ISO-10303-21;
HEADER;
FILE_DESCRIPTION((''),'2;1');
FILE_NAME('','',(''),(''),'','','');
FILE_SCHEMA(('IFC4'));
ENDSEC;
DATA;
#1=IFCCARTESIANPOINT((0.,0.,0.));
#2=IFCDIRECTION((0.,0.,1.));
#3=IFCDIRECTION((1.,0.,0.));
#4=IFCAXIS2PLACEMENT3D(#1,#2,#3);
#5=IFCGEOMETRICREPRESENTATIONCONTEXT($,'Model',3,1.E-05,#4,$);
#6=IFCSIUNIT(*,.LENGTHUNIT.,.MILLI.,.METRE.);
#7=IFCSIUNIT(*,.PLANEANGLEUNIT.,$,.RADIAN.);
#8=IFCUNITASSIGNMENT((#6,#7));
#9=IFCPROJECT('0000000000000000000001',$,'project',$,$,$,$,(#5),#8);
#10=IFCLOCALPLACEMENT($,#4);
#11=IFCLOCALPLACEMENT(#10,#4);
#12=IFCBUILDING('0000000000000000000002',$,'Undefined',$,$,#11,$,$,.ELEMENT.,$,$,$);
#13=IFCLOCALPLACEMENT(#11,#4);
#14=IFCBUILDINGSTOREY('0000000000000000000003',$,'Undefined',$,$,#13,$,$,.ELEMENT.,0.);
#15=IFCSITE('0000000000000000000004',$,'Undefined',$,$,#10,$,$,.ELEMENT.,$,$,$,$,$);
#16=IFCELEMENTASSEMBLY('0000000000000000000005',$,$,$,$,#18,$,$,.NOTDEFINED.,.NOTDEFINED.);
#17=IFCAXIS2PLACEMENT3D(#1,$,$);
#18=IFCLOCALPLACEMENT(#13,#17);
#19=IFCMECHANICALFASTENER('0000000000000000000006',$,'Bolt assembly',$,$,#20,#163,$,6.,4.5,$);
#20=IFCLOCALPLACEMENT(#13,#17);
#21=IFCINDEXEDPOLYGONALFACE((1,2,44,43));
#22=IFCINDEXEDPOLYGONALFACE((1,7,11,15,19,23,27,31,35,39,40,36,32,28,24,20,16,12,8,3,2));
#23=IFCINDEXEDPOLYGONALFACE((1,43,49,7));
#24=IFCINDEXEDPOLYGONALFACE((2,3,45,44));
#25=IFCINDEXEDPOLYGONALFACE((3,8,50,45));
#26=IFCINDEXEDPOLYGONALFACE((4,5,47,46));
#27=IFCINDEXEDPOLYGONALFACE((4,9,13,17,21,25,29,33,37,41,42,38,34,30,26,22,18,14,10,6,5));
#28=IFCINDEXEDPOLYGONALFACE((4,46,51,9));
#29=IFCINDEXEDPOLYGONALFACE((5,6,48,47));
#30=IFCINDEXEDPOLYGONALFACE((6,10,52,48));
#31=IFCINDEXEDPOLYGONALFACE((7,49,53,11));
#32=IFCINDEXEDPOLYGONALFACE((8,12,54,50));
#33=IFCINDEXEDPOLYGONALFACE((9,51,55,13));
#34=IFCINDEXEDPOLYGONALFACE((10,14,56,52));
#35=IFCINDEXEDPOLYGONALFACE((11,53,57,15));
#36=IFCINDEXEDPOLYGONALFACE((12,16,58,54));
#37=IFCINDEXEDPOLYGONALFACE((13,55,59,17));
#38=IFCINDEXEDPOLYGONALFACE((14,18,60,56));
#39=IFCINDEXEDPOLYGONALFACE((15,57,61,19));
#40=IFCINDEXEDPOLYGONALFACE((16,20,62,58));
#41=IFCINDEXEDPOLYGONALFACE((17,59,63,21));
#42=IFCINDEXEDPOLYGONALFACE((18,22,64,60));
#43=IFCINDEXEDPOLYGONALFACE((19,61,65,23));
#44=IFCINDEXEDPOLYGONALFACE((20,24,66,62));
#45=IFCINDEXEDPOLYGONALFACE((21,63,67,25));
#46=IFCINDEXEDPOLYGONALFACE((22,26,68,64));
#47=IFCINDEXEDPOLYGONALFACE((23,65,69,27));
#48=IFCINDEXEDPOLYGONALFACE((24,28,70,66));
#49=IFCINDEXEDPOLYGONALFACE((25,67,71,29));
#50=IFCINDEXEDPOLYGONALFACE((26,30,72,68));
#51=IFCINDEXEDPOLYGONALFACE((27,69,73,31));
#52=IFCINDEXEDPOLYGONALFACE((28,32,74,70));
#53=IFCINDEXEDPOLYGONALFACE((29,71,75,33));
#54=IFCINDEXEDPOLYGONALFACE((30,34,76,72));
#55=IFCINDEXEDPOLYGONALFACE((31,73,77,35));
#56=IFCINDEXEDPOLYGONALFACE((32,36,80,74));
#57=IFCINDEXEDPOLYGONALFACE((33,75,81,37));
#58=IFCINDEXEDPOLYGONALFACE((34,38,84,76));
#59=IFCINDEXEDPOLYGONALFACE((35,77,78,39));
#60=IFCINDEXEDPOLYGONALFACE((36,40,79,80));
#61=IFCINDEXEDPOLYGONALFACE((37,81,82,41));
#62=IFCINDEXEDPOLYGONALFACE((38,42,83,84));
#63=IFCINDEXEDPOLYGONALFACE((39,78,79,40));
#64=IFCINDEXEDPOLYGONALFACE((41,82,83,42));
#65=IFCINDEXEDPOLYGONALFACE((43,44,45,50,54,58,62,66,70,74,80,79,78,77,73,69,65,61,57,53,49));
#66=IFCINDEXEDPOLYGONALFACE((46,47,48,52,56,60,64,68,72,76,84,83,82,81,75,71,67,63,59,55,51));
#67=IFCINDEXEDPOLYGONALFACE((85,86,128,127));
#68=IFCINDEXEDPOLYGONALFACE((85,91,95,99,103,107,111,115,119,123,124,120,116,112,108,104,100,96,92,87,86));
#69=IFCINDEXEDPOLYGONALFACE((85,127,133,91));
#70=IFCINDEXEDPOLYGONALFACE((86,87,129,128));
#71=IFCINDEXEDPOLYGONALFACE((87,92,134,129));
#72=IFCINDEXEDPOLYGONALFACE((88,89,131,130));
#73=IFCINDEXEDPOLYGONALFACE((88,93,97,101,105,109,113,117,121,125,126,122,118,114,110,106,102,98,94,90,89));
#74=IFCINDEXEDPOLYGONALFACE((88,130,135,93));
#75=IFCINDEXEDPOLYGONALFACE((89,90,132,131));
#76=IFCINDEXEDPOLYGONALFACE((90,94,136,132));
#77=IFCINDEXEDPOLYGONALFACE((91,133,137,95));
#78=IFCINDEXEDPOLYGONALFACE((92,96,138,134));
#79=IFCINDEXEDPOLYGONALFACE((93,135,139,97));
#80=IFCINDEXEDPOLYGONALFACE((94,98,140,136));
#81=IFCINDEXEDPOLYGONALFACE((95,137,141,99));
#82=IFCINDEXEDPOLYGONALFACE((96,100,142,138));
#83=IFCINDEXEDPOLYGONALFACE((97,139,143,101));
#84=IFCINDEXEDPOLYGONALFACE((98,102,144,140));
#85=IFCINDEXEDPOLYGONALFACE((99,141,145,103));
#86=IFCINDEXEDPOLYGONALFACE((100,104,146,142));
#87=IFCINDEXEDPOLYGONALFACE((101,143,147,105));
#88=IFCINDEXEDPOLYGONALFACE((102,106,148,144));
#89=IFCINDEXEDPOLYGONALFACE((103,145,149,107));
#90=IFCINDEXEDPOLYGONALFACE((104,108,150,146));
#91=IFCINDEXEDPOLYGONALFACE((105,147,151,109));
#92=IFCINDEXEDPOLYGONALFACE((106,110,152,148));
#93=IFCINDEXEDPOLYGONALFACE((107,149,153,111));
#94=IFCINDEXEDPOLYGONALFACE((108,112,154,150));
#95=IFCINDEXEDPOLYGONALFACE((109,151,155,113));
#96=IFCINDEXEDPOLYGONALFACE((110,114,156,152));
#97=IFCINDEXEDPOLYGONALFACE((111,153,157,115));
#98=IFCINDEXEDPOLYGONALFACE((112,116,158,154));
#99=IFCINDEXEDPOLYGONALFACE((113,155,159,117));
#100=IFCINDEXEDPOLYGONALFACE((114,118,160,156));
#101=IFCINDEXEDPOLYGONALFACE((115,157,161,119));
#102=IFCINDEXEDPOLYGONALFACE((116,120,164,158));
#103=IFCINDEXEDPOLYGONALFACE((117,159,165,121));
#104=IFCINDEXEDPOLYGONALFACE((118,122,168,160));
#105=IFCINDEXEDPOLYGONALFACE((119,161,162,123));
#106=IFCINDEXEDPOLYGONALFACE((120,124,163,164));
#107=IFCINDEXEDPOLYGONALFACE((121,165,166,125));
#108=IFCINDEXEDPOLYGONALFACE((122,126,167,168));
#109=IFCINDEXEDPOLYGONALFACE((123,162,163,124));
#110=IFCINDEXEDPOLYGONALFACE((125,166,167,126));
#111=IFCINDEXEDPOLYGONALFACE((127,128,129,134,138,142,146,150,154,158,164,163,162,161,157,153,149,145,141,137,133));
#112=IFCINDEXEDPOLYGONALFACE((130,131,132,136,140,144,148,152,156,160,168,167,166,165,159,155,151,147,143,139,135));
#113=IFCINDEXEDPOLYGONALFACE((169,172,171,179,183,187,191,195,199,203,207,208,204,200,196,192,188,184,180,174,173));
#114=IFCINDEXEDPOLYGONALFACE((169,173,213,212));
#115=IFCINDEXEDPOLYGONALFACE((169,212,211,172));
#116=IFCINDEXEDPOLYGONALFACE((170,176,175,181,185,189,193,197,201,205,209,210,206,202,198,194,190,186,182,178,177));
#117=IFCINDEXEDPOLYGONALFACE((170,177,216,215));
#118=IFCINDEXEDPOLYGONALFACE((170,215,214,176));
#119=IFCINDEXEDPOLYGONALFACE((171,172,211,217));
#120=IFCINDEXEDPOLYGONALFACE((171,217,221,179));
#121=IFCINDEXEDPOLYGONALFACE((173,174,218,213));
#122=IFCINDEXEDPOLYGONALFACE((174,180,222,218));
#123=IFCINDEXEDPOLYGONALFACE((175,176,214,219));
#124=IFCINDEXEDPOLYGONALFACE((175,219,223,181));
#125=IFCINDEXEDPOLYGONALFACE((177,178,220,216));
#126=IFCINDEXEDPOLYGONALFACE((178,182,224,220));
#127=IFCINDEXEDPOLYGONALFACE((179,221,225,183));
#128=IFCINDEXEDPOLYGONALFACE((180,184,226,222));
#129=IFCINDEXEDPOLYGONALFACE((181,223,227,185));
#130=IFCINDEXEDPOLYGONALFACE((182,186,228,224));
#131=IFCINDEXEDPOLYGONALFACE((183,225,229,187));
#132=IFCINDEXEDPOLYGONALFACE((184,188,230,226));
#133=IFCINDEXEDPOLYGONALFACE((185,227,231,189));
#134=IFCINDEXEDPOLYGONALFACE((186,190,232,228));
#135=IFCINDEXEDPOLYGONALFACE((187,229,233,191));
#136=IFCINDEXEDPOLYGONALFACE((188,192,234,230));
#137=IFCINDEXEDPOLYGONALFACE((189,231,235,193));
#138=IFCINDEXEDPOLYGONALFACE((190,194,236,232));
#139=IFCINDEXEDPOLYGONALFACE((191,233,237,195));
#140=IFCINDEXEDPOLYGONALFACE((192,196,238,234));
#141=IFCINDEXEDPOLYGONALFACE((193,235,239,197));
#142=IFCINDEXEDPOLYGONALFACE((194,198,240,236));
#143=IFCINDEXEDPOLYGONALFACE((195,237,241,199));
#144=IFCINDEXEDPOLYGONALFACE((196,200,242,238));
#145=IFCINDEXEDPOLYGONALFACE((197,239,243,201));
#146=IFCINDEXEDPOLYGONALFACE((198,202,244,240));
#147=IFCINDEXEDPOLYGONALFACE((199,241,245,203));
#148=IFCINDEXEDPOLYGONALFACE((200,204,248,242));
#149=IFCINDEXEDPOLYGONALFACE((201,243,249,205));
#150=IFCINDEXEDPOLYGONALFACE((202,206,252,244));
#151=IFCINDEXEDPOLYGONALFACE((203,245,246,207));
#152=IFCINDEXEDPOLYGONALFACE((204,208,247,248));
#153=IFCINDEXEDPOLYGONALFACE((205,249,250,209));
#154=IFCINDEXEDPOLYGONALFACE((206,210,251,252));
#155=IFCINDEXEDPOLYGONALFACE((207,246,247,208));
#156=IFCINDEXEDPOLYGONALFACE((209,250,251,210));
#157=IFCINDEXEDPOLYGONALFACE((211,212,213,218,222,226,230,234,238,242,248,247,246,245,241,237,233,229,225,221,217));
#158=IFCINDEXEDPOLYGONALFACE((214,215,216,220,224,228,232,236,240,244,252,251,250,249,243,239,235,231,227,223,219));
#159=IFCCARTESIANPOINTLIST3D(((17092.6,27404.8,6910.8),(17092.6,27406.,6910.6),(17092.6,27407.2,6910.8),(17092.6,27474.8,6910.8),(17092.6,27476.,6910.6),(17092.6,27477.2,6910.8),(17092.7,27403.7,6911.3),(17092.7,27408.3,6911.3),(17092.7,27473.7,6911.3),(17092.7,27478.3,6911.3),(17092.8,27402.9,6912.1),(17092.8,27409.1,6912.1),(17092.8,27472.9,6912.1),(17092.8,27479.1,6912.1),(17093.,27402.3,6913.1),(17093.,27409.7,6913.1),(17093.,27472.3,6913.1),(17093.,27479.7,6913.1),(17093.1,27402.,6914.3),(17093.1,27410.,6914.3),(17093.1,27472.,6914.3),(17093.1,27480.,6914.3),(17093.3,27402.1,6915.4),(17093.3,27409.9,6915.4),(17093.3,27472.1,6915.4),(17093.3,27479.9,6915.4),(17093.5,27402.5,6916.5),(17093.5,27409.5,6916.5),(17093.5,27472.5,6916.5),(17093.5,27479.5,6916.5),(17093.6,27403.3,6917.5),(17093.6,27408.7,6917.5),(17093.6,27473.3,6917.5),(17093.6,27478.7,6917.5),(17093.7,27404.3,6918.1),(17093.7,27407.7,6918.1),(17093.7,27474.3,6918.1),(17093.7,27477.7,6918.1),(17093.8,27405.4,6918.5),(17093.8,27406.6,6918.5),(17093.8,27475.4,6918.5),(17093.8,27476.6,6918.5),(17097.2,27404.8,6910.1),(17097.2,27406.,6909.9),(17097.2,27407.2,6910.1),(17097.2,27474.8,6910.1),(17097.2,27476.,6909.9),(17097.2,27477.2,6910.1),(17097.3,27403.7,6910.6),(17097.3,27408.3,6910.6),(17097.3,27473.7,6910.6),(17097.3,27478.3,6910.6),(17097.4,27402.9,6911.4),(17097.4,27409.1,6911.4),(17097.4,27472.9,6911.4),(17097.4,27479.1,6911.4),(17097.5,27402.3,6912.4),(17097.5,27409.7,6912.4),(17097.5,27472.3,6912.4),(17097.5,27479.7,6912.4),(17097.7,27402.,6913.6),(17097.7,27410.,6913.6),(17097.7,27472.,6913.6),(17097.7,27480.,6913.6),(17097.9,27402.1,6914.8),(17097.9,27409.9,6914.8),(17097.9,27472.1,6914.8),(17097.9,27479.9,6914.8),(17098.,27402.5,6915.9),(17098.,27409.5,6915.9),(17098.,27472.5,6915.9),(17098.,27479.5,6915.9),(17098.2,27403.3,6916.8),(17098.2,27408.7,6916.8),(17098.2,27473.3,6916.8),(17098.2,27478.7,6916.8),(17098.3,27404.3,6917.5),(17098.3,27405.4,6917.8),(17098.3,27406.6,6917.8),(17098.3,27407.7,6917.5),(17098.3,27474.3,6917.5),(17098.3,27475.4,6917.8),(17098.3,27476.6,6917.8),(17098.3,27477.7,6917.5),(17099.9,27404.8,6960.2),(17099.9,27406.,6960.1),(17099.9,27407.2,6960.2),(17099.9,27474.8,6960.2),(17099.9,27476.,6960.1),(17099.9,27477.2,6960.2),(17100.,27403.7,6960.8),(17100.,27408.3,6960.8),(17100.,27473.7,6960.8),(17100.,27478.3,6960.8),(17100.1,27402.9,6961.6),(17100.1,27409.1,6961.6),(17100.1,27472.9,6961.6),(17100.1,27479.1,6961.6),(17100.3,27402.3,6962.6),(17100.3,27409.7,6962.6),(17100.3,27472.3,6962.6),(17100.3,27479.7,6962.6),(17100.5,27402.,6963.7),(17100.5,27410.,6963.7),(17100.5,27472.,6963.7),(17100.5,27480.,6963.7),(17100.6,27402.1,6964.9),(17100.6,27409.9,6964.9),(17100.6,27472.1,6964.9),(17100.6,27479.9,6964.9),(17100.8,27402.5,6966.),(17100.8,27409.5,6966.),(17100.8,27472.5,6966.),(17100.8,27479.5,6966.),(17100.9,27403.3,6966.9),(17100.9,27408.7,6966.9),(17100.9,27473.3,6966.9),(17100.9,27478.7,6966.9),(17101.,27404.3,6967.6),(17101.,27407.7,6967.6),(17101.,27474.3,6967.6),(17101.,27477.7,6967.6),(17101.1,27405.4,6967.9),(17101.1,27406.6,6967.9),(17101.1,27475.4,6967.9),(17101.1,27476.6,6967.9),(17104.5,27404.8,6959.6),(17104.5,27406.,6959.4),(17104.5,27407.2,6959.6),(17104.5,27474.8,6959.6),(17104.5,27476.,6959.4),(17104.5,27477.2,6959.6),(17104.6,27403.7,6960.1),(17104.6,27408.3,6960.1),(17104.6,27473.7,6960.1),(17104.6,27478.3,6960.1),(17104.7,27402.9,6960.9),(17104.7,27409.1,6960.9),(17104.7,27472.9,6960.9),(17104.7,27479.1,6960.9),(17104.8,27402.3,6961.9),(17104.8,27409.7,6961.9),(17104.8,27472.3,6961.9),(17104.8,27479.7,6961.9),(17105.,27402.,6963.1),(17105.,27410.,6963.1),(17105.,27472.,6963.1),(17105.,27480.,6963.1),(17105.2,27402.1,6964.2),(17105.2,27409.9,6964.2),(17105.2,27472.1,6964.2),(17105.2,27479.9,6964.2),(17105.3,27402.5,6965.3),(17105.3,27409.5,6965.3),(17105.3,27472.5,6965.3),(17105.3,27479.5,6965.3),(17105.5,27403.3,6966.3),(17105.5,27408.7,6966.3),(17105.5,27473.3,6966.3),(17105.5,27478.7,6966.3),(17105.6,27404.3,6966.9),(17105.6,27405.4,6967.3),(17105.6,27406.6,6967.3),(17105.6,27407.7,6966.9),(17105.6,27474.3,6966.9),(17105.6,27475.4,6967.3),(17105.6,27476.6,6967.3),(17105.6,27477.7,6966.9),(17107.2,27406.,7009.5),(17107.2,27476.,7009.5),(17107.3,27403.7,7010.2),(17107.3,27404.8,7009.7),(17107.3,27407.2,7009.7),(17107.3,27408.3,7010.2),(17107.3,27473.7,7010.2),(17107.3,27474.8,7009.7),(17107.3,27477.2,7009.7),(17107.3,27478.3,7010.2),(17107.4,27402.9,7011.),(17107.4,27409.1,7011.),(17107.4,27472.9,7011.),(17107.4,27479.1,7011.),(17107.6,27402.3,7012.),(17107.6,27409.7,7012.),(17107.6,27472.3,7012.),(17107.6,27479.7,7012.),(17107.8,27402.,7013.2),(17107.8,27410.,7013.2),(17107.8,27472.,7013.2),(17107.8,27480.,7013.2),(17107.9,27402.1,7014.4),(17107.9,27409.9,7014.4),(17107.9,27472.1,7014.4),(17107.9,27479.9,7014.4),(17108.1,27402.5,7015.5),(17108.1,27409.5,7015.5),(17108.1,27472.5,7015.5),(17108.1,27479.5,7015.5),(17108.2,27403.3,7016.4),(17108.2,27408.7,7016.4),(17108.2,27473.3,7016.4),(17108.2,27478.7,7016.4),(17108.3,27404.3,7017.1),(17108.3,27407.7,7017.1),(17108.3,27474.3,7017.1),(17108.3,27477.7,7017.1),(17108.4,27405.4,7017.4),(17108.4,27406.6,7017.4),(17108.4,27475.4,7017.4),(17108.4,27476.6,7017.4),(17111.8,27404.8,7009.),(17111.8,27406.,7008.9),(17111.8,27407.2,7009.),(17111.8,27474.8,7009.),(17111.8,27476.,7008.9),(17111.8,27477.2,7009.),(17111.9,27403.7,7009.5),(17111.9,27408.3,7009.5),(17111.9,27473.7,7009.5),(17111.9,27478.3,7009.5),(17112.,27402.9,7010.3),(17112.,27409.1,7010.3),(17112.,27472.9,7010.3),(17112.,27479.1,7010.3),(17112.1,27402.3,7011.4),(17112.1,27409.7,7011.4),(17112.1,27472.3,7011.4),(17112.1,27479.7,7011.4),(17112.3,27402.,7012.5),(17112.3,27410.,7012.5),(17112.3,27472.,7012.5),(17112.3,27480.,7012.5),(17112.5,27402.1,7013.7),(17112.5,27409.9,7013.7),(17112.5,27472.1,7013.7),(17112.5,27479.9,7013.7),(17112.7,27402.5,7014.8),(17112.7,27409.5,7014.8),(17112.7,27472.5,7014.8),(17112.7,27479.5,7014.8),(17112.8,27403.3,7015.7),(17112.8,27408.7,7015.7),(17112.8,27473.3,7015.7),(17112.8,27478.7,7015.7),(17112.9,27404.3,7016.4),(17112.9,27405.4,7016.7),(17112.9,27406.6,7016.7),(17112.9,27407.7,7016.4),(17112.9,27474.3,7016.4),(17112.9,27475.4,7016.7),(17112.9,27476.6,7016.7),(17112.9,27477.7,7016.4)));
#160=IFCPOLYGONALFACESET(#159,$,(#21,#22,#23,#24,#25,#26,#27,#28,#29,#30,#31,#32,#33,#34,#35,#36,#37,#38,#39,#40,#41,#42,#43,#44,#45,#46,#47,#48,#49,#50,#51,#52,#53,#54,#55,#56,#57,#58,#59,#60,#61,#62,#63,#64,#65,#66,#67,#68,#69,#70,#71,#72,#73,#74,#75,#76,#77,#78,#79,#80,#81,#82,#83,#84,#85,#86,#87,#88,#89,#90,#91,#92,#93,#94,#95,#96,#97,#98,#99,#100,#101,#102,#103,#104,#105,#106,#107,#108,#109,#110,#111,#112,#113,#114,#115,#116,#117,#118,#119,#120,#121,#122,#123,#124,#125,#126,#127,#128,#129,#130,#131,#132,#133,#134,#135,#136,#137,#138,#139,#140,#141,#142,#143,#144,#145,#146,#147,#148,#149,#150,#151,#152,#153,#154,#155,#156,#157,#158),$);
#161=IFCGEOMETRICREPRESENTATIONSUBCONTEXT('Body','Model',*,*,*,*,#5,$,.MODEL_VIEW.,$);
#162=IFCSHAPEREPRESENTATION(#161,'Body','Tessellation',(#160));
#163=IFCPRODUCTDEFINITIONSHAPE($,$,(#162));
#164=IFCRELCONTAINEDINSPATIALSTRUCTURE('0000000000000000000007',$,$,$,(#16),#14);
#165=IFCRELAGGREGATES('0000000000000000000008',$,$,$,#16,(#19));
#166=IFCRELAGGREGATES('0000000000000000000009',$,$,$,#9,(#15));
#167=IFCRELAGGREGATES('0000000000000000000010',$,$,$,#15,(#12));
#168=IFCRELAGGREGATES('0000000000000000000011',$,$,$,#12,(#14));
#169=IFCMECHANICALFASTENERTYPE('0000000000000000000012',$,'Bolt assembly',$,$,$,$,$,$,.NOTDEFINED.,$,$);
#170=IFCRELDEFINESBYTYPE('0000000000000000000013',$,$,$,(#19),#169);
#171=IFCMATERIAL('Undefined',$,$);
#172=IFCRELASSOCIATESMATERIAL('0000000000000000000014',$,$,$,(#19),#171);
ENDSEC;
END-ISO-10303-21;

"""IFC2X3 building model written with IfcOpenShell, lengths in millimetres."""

from ifc_helpers import new_model, si_unit, frame, origin_with_axes, origin_2d_with_axis, place, context, subcontext, project, spatial, circle, extrude, source, transform, mapped, material, type_object, element, aggregate, save


model = new_model("IFC2X3")

# Units and contexts
model_context = context("Model", 3, precision=1e-05, world=origin_with_axes())
body_context = subcontext(model_context, "Body", "Model", "MODEL_VIEW")
ifc_project = project(units=[si_unit("LENGTHUNIT", "METRE", prefix="MILLI"), si_unit("PLANEANGLEUNIT", "RADIAN")], contexts=[model_context])

# Site, building, storey
site_placement = place(None, origin_with_axes())
site = spatial("IfcSite", under=ifc_project, at=site_placement, Name="Undefined", CompositionType="ELEMENT")
building_placement = place(site_placement, origin_with_axes())
building = spatial("IfcBuilding", under=site, at=building_placement, Name="Undefined", CompositionType="ELEMENT")
storey_placement = place(building_placement, origin_with_axes())
storey = spatial("IfcBuildingStorey", under=building, at=storey_placement, Name="Undefined", CompositionType="ELEMENT", Elevation=0.0)

# Element assembly
assembly_1_placement = place(storey_placement, origin_with_axes())
assembly_1 = element("IfcElementAssembly", 1, at=assembly_1_placement, inside=storey, AssemblyPlace="NOTDEFINED", PredefinedType="NOTDEFINED")

# Mechanical fastener
ifc_material_1 = material(Name="Undefined")
mechanical_fastener_type = type_object("IfcMechanicalFastenerType", Name="Bolt assembly")
shared_shape_1 = source(origin_with_axes(), body_context, "Body", "SweptSolid", [
    extrude(circle(Radius=4.0, at=origin_2d_with_axis()), frame((0.0, 0.0, 0.0), z_axis=(0.0, 1.0, 0.0), x_axis=(1.0, 0.0, 0.0)), (0.0, 0.0, 1.0), 4.6),
])
mechanical_fastener_1_placement = place(assembly_1_placement, frame((17112.4, 27441.0, 7012.8), z_axis=(0.0, 1.0, 0.0), x_axis=(-0.146202, 0.0, -0.989255)))
mechanical_fastener_1 = element("IfcMechanicalFastener", 2, at=mechanical_fastener_1_placement, type_object=mechanical_fastener_type, material=ifc_material_1, Name="Bolt assembly", NominalDiameter=6.0, NominalLength=4.5, context=body_context, shape_type="MappedRepresentation", body=[
    mapped(shared_shape_1, transform((0.0, 0.0, 35.0))),
    mapped(shared_shape_1, transform((50.0, 0.0, 35.0))),
    mapped(shared_shape_1, transform((100.0, 0.0, 35.0))),
    mapped(shared_shape_1, transform((0.0, 0.0, -35.0))),
    mapped(shared_shape_1, transform((50.0, 0.0, -35.0))),
    mapped(shared_shape_1, transform((100.0, 0.0, -35.0))),
])

aggregate(assembly_1, [mechanical_fastener_1])

save(model, "model.ifc")
